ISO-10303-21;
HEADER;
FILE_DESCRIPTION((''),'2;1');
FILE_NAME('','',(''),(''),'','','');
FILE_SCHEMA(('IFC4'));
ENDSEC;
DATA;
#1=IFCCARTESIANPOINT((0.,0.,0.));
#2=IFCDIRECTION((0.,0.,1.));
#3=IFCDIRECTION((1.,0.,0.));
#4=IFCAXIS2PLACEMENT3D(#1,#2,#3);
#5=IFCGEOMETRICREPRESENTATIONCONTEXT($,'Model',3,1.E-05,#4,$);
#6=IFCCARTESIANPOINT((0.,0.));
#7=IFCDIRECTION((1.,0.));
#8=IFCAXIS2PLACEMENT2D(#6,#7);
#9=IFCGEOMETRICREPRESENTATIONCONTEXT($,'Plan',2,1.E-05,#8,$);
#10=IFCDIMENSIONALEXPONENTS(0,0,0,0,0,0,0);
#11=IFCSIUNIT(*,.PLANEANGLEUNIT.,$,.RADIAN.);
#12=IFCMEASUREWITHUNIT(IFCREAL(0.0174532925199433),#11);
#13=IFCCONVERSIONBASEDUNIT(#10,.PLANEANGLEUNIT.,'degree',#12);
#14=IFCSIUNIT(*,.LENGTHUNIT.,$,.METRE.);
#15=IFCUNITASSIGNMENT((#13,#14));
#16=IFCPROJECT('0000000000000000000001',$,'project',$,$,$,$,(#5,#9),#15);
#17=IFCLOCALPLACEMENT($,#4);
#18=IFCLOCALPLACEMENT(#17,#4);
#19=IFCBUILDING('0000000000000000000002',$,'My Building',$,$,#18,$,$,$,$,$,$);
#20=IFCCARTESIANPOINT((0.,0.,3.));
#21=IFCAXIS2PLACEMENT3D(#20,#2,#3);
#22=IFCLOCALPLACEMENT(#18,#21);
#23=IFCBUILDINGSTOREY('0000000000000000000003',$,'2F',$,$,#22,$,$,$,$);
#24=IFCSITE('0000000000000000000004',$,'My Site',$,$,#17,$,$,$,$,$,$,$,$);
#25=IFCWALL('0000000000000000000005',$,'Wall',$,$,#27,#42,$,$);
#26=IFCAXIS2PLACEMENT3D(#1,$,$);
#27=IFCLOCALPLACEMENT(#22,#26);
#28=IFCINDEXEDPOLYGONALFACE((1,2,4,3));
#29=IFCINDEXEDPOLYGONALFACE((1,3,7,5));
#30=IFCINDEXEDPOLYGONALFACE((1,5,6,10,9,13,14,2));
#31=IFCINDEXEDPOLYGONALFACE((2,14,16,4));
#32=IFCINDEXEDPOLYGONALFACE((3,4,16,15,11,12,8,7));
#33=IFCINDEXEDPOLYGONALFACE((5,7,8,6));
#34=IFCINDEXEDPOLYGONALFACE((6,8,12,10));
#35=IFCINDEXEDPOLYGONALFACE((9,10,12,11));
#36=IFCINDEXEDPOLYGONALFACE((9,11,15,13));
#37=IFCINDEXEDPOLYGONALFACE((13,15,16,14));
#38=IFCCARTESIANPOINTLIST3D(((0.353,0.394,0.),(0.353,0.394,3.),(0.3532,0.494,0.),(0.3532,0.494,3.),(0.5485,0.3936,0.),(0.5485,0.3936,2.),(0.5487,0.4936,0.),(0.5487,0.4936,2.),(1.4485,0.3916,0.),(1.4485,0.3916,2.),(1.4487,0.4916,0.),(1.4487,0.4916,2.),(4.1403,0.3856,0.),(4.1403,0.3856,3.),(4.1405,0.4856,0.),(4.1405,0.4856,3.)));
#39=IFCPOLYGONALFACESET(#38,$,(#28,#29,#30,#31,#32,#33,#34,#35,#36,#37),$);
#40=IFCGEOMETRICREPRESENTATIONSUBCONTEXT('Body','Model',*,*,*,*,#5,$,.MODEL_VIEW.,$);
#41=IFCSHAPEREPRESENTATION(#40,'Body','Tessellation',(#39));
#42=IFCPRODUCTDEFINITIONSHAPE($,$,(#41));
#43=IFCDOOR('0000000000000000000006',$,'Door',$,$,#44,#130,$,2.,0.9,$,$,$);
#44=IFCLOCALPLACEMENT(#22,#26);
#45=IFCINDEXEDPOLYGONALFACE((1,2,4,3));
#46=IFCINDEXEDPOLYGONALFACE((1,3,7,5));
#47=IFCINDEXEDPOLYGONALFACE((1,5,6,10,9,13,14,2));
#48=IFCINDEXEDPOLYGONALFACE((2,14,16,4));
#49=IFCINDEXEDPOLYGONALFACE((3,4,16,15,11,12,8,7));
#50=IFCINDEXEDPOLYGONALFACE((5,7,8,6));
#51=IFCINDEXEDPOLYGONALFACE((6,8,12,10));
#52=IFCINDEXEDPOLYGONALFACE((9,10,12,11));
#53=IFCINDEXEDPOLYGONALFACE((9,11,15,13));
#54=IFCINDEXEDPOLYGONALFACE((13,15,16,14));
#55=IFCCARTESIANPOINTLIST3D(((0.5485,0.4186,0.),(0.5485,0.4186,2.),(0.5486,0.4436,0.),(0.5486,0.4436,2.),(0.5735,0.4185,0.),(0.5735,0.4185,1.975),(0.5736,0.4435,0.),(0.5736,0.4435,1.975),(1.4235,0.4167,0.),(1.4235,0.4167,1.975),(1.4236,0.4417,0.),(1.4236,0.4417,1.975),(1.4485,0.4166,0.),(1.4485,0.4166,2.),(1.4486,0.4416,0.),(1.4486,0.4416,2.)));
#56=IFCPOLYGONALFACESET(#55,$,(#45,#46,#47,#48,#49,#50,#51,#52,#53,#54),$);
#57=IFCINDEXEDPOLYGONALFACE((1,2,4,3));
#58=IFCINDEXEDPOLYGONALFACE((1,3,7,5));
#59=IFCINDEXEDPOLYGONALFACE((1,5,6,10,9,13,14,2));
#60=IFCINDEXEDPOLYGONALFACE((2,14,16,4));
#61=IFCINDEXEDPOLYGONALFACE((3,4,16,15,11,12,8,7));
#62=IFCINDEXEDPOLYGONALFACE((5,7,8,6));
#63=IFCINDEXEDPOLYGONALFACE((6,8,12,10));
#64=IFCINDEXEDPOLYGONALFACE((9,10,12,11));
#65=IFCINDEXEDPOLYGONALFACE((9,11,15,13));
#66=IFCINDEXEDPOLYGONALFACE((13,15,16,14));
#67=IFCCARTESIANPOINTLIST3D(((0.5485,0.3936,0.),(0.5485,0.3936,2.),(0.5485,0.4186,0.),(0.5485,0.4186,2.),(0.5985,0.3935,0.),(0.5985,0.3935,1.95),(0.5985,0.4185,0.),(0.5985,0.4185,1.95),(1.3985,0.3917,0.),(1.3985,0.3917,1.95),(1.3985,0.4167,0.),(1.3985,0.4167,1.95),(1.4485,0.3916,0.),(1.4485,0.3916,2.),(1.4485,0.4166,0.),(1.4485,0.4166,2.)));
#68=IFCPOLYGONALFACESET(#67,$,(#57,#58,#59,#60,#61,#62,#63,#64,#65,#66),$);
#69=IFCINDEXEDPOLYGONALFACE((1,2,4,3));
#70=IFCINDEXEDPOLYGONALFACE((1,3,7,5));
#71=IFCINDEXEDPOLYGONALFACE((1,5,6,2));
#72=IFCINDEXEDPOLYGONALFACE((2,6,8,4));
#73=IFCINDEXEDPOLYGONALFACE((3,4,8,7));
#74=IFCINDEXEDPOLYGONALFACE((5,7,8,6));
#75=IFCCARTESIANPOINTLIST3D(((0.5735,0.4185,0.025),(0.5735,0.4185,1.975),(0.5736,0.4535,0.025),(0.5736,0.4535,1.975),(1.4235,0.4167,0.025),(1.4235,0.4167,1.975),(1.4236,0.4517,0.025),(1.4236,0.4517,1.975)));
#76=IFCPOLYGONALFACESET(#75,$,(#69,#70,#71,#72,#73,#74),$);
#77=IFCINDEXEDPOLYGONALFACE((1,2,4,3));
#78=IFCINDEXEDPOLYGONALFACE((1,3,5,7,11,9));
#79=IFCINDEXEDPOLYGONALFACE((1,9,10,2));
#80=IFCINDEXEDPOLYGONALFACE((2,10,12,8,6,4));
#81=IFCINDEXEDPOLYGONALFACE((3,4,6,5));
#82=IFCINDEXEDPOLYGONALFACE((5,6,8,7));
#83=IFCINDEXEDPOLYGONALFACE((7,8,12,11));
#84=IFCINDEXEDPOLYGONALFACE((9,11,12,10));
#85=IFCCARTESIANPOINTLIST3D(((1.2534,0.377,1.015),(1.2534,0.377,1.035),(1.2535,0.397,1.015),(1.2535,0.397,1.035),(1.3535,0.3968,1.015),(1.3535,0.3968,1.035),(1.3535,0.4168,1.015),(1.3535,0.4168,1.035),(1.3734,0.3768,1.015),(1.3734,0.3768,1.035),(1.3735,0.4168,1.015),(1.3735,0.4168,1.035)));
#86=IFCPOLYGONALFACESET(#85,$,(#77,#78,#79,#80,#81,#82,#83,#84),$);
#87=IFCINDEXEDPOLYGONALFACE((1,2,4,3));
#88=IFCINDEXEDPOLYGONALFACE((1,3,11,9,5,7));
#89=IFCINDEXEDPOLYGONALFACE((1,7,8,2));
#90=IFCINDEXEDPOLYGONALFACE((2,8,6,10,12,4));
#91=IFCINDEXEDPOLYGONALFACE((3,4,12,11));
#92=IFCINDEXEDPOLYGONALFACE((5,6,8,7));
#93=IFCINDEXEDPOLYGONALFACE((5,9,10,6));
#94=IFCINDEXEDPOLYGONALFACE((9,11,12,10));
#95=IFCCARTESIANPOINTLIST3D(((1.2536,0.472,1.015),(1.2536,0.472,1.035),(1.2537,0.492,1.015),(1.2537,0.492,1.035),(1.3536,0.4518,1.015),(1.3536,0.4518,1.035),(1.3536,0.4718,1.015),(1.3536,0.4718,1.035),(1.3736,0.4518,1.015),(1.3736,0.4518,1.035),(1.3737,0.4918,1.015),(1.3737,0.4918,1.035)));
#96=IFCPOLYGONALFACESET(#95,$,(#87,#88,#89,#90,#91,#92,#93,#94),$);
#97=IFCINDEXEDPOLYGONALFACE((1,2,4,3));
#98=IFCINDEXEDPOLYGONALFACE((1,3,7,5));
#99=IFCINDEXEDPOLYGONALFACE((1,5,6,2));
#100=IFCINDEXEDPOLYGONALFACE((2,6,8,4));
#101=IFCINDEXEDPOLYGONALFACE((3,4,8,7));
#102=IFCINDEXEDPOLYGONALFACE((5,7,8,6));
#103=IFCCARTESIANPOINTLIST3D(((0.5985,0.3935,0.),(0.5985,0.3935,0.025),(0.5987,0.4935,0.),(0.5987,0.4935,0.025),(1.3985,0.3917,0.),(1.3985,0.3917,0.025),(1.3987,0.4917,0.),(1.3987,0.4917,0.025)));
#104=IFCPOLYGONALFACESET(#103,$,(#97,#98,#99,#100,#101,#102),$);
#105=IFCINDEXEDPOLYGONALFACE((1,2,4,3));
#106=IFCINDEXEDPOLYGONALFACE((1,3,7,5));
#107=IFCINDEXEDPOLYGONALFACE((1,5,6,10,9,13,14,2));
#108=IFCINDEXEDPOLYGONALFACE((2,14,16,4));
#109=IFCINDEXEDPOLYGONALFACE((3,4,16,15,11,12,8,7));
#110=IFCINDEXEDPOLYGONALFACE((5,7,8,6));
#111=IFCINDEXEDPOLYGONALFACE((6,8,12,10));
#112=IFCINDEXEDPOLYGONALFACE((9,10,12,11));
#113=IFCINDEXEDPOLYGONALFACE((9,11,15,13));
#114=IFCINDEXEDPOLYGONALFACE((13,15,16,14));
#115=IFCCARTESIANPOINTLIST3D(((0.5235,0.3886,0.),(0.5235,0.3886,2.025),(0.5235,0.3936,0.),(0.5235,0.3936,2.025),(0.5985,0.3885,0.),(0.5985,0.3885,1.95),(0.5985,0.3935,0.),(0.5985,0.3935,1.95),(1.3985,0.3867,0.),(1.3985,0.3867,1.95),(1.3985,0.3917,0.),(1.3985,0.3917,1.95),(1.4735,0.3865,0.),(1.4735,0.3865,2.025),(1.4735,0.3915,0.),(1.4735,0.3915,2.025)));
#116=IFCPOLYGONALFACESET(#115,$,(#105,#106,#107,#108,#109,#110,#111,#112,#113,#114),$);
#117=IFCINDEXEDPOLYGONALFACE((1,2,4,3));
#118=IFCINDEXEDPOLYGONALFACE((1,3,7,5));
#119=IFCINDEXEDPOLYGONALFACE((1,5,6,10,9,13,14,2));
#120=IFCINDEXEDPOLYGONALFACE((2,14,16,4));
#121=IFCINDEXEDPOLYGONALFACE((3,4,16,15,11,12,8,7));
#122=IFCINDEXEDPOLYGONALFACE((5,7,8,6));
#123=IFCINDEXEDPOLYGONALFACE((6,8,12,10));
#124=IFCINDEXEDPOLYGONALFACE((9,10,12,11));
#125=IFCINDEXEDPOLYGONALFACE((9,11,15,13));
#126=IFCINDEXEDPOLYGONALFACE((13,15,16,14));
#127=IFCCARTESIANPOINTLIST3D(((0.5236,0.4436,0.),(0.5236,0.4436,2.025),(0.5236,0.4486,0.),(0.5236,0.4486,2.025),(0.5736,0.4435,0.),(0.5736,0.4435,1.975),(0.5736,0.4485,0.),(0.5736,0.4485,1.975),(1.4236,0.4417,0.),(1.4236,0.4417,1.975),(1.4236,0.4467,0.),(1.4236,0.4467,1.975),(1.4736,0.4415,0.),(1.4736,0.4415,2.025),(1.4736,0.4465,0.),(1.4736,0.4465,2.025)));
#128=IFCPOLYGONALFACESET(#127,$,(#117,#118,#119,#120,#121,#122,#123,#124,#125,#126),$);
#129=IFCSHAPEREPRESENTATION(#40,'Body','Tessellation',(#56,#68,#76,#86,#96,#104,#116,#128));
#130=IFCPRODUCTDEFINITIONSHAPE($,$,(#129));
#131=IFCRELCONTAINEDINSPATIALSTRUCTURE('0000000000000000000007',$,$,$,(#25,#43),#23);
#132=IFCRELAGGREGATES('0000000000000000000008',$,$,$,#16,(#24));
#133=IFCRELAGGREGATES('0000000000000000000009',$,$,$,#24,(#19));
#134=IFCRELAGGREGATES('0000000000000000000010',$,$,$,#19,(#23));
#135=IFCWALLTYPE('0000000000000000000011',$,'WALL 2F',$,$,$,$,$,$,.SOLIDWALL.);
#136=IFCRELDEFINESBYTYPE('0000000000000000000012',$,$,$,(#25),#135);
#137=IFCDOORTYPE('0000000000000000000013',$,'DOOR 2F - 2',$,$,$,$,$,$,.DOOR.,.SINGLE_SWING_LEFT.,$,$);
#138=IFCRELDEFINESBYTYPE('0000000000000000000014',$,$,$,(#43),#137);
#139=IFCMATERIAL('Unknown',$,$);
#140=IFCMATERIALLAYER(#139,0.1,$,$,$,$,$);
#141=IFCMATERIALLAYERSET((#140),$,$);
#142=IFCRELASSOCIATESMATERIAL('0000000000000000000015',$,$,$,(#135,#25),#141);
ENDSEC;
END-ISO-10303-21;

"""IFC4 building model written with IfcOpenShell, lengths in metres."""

from ifc_helpers import new_model, entity, si_unit, converted_unit, frame, origin_with_axes, origin_2d_with_axis, place, context, subcontext, project, spatial, line, indexed_curve, outline, extrude, shape, source, transform, mapped, material, layer, layer_set, layer_usage, type_object, type_shapes, element, fill, save


model = new_model("IFC4")

# Units and contexts
model_context = context("Model", 3, precision=1e-05, world=origin_with_axes())
plan_context = context("Plan", 2, precision=1e-05, world=origin_2d_with_axis())
body_context_1 = subcontext(model_context, "Body", "Model", "MODEL_VIEW")
body_context_2 = subcontext(plan_context, "Body", "Plan", "PLAN_VIEW")
ifc_project = project(units=[converted_unit("PLANEANGLEUNIT", "degree", entity("IfcReal", 0.0174532925199433), si_unit("PLANEANGLEUNIT", "RADIAN"), dimensions=[0, 0, 0, 0, 0, 0, 0]), si_unit("LENGTHUNIT", "METRE")], contexts=[model_context, plan_context])

# Site, building, storey
site_placement = place(None, origin_with_axes())
site = spatial("IfcSite", under=ifc_project, at=site_placement, Name="My Site")
building_placement = place(site_placement, origin_with_axes())
building = spatial("IfcBuilding", under=site, at=building_placement, Name="My Building")
storey_placement = place(building_placement, frame((0.0, 0.0, 3.0), z_axis=(0.0, 0.0, 1.0), x_axis=(1.0, 0.0, 0.0)))
storey = spatial("IfcBuildingStorey", under=building, at=storey_placement, Name="2F")

# Shared definitions
ifc_material = material(Name="Unknown")

# Shared definitions
ifc_layer_1 = layer(ifc_material, 0.1)
ifc_layer_set_1 = layer_set([ifc_layer_1])
wall_type = type_object("IfcWallType", Name="WALL 2F", PredefinedType="SOLIDWALL", material=ifc_layer_set_1)

# Shared definitions
shared_shape_1 = source(origin_with_axes(), body_context_1, "Body", "SweptSolid", [
    extrude(outline(indexed_curve([(0.0, 0.0), (0.9, 0.0), (0.9, 2.0), (0.0, 2.0)], segments=[line(1, 2, 3, 4, 1)])), frame((0.0, -0.6, 0.0), z_axis=(0.0, -1.0, 0.0), x_axis=(1.0, 0.0, 0.0)), (0.0, 0.0, -1.0), 1.2),
])
door_type_1 = type_object("IfcDoorType", Name="DOOR 2F - 2", OperationType="SINGLE_SWING_LEFT", PredefinedType="DOOR")
shared_shape_2 = source(origin_with_axes(), body_context_1, "Body", "SweptSolid", [
    extrude(outline(indexed_curve([(0.0, 0.0), (0.0, 2.0), (0.9, 2.0), (0.9, 0.0), (0.875, 0.0), (0.875, 1.975), (0.025, 1.975), (0.025, 0.0)], segments=[line(1, 2, 3, 4, 5, 6, 7, 8, 1)])), frame((0.0, 0.025, 0.0), z_axis=(0.0, -1.0, 0.0), x_axis=(1.0, 0.0, 0.0)), (0.0, 0.0, -1.0), 0.025),
    extrude(outline(indexed_curve([(0.0, 0.0), (0.0, 2.0), (0.9, 2.0), (0.9, 0.0), (0.85, 0.0), (0.85, 1.95), (0.05, 1.95), (0.05, 0.0)], segments=[line(1, 2, 3, 4, 5, 6, 7, 8, 1)])), frame((0.0, 0.0, 0.0), z_axis=(0.0, -1.0, 0.0), x_axis=(1.0, 0.0, 0.0)), (0.0, 0.0, -1.0), 0.025),
    extrude(outline(indexed_curve([(0.0, 0.0), (0.85, 0.0), (0.85, 0.035), (0.0, 0.035)], segments=[line(1, 2, 3, 4, 1)])), frame((0.025, 0.025, 0.025), z_axis=(0.0, 0.0, 1.0), x_axis=(1.0, 0.0, 0.0)), (0.0, 0.0, 1.0), 1.95),
    extrude(outline(indexed_curve([(0.0, 0.0), (0.0, -0.04), (-0.12, -0.04), (-0.12, -0.02), (-0.02, -0.02), (-0.02, 0.0)], segments=[line(1, 2, 3, 4, 5, 6, 1)])), frame((0.825, 0.025, 1.015), z_axis=(0.0, 0.0, 1.0), x_axis=(1.0, 0.0, 0.0)), (0.0, 0.0, 1.0), 0.02),
    extrude(outline(indexed_curve([(0.0, 0.0), (0.0, 0.04), (-0.12, 0.04), (-0.12, 0.02), (-0.02, 0.02), (-0.02, 0.0)], segments=[line(1, 2, 3, 4, 5, 6, 1)])), frame((0.825, 0.06, 1.015), z_axis=(0.0, 0.0, 1.0), x_axis=(1.0, 0.0, 0.0)), (0.0, 0.0, 1.0), 0.02),
    extrude(outline(indexed_curve([(0.0, 0.0), (0.8, 0.0), (0.8, 0.1), (0.0, 0.1)], segments=[line(1, 2, 3, 4, 1)])), frame((0.05, 0.0, 0.0), z_axis=(0.0, 0.0, 1.0), x_axis=(1.0, 0.0, 0.0)), (0.0, 0.0, 1.0), 0.025),
    extrude(outline(indexed_curve([(0.0, 0.0), (0.0, 2.025), (0.95, 2.025), (0.95, 0.0), (0.875, 0.0), (0.875, 1.95), (0.075, 1.95), (0.075, 0.0)], segments=[line(1, 2, 3, 4, 5, 6, 7, 8, 1)])), frame((-0.025, -0.005, 0.0), z_axis=(0.0, -1.0, 0.0), x_axis=(1.0, 0.0, 0.0)), (0.0, 0.0, -1.0), 0.005),
    extrude(outline(indexed_curve([(0.0, 0.0), (0.0, 2.025), (0.95, 2.025), (0.95, 0.0), (0.9, 0.0), (0.9, 1.975), (0.05, 1.975), (0.05, 0.0)], segments=[line(1, 2, 3, 4, 5, 6, 7, 8, 1)])), frame((-0.025, 0.05, 0.0), z_axis=(0.0, -1.0, 0.0), x_axis=(1.0, 0.0, 0.0)), (0.0, 0.0, -1.0), 0.005),
])
shared_shape_3 = source(origin_with_axes(), body_context_2, "Body", "Curve2D", [
    entity("IfcIndexedPolyCurve", entity("IfcCartesianPointList2D", [[0.0, 0.0], [0.0, 0.05], [0.025, 0.05], [0.025, 0.025], [0.05, 0.025], [0.05, 0.0]]), [entity("IfcLineIndex", [1, 2, 3, 4, 5, 6, 1])]),
    entity("IfcIndexedPolyCurve", entity("IfcCartesianPointList2D", [[0.9, 0.0], [0.9, 0.05], [0.875, 0.05], [0.875, 0.025], [0.85, 0.025], [0.85, 0.0]]), [entity("IfcLineIndex", [1, 2, 3, 4, 5, 6, 1])]),
    entity("IfcTrimmedCurve", entity("IfcEllipse", entity("IfcAxis2Placement2D", entity("IfcCartesianPoint", [0.06, 0.05]), entity("IfcDirection", [1.0, 0.0])), 0.815, 0.85), [entity("IfcCartesianPoint", [0.875, 0.05])], [entity("IfcCartesianPoint", [0.06, 0.9])], True, "CARTESIAN"),
    entity("IfcIndexedPolyCurve", entity("IfcCartesianPointList2D", [[0.025, 0.05], [0.06, 0.05], [0.06, 0.9], [0.025, 0.9]]), [entity("IfcLineIndex", [1, 2, 3, 4, 1])]),
])
type_shapes(door_type_1, [shared_shape_2, shared_shape_3])

# Wall, opening, door
ifc_layer_usage_1 = layer_usage(ifc_layer_set_1, "AXIS2", "POSITIVE", 0.0)
wall_1_placement = place(storey_placement, frame((0.353, 0.394, 0.0), z_axis=(0.0, 0.0, 1.0), x_axis=(0.999998, -0.002218, 0.0)))
wall_1 = element("IfcWall", 1, at=wall_1_placement, inside=storey, type_object=wall_type, material=ifc_layer_usage_1, Name="Wall", context=body_context_1, shape_type="SweptSolid", body=[
    extrude(outline(indexed_curve([(0.0, 0.0), (0.0, 0.1), (3.7873, 0.1), (3.7873, 0.0)], segments=[line(1, 2, 3, 4, 1)])), origin_with_axes(), (0.0, 0.0, 1.0), 3.0),
])
opening_1_placement = place(wall_1_placement, frame((0.1955, 0.0, 0.0), z_axis=(0.0, 0.0, 1.0), x_axis=(1.0, 0.0, 0.0)))
opening_1 = element("IfcOpeningElement", 2, at=opening_1_placement, cuts=wall_1, PredefinedType="OPENING", context=body_context_1, shape_type="MappedRepresentation", body=[
    mapped(shared_shape_1, transform((0.0, 0.0, 0.0), x_axis=(1.0, 0.0, 0.0), y_axis=(0.0, 1.0, 0.0), z_axis=(0.0, 0.0, 1.0), scale=1.0)),
])
door_1_placement = place(opening_1_placement, origin_with_axes())
door_1 = element("IfcDoor", 3, at=door_1_placement, inside=storey, type_object=door_type_1, Name="Door", OverallHeight=2.0, OverallWidth=0.9, shapes=[
    shape(body_context_1, "Body", "MappedRepresentation", [mapped(shared_shape_2, transform((0.0, 0.0, 0.0), x_axis=(1.0, 0.0, 0.0), y_axis=(0.0, 1.0, 0.0), z_axis=(0.0, 0.0, 1.0), scale=1.0))]),
    shape(body_context_2, "Body", "MappedRepresentation", [mapped(shared_shape_3, transform((0.0, 0.0, 0.0), x_axis=(1.0, 0.0, 0.0), y_axis=(0.0, 1.0, 0.0), z_axis=(0.0, 0.0, 1.0), scale=1.0))]),
])
fill(opening_1, door_1)

save(model, "model.ifc")
